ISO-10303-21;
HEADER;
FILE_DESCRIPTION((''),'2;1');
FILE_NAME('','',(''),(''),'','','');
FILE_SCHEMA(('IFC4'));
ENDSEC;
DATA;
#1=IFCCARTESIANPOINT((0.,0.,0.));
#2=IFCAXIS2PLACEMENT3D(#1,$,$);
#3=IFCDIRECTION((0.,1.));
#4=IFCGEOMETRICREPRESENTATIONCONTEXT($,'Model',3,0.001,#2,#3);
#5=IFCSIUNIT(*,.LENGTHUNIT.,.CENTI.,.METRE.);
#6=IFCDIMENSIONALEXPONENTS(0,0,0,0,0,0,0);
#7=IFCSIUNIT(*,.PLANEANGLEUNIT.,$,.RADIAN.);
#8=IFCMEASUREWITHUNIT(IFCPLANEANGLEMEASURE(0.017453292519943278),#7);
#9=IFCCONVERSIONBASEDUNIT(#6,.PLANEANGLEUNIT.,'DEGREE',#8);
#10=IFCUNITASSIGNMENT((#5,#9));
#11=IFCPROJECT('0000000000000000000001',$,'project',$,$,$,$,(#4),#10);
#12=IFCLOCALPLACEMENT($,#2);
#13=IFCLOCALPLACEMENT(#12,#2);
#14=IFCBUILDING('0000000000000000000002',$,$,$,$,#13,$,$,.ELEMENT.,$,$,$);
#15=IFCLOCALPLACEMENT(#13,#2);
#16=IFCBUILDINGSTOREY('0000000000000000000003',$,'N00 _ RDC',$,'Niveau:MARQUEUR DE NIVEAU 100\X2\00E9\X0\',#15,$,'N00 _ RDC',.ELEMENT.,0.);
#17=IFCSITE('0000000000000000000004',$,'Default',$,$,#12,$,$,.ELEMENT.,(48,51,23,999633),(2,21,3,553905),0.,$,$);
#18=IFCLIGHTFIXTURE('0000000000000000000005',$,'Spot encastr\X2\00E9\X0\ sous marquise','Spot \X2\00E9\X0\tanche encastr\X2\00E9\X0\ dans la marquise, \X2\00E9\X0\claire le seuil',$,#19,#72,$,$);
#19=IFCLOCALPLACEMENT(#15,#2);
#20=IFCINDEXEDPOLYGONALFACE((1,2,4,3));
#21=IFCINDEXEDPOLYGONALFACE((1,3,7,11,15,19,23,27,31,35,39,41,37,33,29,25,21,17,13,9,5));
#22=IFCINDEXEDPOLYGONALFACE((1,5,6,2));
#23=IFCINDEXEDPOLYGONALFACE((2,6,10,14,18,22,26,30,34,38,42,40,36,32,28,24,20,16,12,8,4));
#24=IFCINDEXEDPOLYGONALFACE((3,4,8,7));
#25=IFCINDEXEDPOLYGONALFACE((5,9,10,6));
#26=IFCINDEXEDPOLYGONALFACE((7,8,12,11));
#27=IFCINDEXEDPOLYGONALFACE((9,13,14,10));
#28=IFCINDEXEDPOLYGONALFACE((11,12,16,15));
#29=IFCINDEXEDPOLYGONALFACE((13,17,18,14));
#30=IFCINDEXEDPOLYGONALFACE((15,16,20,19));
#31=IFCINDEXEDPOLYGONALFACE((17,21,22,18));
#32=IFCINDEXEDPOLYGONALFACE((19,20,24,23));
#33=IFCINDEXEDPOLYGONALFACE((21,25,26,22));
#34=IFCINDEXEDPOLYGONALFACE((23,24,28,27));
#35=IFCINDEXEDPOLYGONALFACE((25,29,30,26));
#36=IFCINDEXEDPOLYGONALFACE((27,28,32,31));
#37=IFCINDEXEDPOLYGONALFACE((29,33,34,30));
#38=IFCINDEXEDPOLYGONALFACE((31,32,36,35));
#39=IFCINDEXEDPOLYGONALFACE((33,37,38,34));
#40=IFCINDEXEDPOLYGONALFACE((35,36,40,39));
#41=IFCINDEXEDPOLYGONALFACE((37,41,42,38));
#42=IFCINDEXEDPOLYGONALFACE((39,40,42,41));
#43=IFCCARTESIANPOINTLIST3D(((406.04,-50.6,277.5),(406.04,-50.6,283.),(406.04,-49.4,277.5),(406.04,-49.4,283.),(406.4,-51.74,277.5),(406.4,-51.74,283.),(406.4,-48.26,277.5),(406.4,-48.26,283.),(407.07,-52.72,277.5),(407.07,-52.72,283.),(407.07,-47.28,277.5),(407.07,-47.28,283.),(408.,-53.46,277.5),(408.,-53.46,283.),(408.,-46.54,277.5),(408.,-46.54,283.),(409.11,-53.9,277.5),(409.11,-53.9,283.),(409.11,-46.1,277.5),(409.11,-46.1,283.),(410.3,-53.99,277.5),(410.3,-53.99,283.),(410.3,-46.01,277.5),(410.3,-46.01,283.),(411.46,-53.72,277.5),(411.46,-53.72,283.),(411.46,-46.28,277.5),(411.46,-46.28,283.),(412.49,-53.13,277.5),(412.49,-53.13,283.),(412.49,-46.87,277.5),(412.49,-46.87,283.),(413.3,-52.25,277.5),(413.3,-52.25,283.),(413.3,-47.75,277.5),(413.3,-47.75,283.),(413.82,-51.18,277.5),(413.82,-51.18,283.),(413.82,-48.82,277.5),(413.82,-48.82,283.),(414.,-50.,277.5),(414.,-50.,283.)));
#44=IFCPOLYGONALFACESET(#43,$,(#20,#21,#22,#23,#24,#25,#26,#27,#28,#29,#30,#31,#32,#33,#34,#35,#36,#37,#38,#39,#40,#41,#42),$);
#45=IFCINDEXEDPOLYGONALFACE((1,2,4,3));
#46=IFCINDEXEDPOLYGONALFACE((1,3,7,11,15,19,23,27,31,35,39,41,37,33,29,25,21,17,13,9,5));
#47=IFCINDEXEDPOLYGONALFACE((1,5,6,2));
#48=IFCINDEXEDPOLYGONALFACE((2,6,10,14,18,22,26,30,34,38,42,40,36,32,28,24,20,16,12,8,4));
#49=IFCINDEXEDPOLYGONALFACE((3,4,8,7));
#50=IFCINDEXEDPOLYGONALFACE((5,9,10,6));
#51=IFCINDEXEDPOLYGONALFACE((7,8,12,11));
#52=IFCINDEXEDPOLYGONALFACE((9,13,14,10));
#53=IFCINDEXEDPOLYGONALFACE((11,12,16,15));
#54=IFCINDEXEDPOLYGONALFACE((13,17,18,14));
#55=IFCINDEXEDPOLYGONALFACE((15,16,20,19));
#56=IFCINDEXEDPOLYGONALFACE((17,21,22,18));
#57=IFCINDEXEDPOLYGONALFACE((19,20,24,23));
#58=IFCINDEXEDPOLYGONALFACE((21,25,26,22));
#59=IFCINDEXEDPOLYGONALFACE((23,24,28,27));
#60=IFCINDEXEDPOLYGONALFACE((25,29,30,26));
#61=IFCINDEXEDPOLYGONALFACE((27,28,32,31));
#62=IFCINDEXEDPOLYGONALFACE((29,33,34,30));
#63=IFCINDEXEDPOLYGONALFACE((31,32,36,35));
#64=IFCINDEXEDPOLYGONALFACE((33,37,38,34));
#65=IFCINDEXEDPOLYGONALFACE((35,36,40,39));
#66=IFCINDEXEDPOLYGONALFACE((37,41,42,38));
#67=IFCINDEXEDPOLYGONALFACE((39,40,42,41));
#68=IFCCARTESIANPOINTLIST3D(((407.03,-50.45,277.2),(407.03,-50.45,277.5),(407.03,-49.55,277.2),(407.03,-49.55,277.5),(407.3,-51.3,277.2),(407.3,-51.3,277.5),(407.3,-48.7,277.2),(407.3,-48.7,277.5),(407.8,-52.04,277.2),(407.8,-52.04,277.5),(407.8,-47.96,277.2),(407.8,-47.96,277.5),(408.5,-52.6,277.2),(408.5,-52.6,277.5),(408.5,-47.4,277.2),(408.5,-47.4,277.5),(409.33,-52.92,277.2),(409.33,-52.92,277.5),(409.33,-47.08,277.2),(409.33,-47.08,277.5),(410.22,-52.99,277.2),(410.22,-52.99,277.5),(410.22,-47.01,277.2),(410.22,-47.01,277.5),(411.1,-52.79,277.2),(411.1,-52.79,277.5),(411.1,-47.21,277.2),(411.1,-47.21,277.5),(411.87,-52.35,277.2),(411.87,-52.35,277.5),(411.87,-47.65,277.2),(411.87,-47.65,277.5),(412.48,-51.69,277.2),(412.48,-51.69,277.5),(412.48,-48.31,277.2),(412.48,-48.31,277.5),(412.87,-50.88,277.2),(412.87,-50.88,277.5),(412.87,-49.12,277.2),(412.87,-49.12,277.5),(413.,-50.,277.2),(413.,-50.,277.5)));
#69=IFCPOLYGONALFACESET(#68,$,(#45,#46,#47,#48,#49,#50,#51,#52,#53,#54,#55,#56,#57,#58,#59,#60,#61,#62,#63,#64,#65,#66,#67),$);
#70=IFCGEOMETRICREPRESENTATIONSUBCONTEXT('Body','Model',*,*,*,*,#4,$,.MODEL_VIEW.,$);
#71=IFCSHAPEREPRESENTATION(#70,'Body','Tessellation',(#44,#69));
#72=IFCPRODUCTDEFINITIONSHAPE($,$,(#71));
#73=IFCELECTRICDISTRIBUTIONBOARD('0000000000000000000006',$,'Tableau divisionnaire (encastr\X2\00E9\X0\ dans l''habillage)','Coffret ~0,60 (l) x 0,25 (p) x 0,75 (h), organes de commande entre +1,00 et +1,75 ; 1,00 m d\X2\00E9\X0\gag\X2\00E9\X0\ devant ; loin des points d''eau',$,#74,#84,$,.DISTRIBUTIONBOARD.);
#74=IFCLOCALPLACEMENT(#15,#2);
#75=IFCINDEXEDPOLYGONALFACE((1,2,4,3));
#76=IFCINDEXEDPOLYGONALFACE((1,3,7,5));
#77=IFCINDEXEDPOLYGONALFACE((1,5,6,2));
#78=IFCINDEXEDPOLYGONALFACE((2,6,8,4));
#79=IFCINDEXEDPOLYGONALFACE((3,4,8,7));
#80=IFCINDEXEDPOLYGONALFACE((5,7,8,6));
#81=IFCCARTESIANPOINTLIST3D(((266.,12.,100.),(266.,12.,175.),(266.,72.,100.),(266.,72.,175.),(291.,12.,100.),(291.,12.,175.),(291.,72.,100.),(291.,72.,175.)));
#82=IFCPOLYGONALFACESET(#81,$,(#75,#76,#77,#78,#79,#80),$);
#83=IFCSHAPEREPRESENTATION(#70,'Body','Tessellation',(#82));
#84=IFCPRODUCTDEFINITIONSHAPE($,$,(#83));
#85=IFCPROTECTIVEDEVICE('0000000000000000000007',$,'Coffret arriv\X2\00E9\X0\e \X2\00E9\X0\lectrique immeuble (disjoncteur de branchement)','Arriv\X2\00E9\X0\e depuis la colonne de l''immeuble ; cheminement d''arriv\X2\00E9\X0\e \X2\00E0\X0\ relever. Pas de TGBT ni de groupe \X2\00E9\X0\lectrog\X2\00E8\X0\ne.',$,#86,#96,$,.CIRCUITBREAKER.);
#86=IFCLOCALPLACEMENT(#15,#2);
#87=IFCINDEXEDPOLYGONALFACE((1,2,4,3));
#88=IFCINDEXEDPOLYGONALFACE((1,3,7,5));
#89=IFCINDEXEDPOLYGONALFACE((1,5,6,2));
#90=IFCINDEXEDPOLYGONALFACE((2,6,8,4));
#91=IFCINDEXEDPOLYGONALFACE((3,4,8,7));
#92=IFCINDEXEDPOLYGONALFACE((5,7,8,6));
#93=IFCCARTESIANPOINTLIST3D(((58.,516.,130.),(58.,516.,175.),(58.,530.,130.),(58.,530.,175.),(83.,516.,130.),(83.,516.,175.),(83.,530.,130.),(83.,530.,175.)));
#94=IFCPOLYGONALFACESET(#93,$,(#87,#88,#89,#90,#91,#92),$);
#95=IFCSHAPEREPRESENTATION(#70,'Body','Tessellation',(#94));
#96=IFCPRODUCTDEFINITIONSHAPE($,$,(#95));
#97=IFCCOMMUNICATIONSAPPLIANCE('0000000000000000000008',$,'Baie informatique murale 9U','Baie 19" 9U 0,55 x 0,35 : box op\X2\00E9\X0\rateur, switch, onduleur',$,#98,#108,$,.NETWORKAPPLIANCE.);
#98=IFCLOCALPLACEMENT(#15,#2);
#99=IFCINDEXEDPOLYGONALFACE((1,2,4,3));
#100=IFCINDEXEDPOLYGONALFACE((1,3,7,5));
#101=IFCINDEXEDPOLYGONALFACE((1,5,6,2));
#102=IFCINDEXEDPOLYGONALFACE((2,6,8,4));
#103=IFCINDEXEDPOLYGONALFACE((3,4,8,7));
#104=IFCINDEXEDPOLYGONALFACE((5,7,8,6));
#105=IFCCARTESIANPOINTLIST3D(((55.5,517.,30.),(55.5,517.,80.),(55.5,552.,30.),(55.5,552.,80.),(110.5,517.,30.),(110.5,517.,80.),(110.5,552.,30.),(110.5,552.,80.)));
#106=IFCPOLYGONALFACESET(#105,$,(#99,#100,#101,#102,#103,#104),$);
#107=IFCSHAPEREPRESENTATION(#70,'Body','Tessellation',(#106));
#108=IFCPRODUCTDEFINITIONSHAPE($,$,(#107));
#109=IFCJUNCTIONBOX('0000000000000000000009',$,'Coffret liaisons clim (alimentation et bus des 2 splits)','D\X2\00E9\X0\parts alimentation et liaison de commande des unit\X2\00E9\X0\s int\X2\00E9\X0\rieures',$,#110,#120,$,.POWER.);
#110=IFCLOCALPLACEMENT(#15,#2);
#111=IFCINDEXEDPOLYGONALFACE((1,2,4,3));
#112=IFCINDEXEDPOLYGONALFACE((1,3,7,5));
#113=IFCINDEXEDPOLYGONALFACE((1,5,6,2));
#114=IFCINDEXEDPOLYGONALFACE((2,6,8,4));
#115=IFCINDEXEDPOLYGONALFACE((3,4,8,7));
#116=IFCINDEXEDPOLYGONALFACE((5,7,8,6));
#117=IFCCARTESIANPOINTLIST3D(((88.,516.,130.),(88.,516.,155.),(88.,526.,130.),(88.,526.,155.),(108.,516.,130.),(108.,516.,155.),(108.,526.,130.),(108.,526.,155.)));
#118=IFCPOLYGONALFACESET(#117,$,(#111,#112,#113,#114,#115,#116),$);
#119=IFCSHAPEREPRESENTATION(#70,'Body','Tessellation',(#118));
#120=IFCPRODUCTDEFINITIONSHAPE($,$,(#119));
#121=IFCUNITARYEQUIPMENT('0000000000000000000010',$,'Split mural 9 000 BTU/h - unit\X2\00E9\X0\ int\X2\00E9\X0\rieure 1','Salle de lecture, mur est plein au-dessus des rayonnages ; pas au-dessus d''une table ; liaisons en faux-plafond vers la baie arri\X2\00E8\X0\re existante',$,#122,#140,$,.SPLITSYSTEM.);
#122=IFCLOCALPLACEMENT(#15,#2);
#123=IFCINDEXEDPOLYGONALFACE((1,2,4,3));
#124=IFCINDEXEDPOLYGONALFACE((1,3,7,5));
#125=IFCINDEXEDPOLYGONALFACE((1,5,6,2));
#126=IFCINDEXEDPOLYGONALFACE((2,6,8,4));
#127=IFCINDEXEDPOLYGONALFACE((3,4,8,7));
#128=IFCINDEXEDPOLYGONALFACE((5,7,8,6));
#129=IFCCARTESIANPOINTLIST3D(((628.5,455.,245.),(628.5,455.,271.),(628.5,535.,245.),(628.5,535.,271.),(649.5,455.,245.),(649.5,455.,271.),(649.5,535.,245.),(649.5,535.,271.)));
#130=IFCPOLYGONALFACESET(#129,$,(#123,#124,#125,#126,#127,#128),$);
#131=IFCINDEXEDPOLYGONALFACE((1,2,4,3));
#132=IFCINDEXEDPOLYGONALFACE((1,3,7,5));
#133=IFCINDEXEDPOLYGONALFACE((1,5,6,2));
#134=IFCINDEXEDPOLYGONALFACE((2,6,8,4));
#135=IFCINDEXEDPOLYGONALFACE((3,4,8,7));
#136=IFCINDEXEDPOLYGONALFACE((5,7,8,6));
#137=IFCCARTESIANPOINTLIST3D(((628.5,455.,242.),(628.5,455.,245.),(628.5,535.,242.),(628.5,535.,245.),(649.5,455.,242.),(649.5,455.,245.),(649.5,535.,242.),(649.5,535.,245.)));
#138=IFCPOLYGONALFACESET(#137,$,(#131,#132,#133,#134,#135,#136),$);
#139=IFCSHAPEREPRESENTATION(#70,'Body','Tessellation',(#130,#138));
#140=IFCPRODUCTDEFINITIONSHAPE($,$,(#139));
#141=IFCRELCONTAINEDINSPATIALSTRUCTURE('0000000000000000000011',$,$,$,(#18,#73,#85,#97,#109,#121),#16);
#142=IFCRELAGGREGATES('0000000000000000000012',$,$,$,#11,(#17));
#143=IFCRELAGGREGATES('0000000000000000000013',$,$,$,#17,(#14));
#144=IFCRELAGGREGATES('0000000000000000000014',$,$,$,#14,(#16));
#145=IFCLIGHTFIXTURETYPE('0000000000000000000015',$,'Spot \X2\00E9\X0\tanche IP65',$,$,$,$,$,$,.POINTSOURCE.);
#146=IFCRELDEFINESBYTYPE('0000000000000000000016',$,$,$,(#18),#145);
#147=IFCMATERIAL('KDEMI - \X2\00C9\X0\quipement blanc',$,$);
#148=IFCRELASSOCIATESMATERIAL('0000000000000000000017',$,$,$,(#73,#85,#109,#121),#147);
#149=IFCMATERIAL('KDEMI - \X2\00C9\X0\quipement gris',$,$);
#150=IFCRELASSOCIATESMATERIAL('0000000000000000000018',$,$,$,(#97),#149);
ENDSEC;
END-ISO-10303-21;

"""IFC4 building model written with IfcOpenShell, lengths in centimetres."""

from ifc_helpers import new_model, entity, si_unit, converted_unit, direction, frame, frame_2d, origin, origin_with_axes, place, context, subcontext, project, spatial, rectangle, circle, extrude, material, type_object, element, save


model = new_model("IFC4")

# Units and contexts
model_context = context("Model", 3, precision=0.001, world=origin(), true_north=direction((0.0, 1.0)))
body_context = subcontext(model_context, "Body", "Model", "MODEL_VIEW")
ifc_project = project(units=[si_unit("LENGTHUNIT", "METRE", prefix="CENTI"), converted_unit("PLANEANGLEUNIT", "DEGREE", entity("IfcPlaneAngleMeasure", 0.017453292519943278), si_unit("PLANEANGLEUNIT", "RADIAN"), dimensions=[0, 0, 0, 0, 0, 0, 0])], contexts=[model_context])

# Site, building, storey
site_placement = place(None, origin())
site = spatial("IfcSite", under=ifc_project, at=site_placement, Name="Default", CompositionType="ELEMENT", RefLatitude=(48, 51, 23, 999633), RefLongitude=(2, 21, 3, 553905), RefElevation=0.0)
building_placement = place(site_placement, origin())
building = spatial("IfcBuilding", under=site, at=building_placement, CompositionType="ELEMENT")
storey_placement = place(building_placement, origin())
storey = spatial("IfcBuildingStorey", under=building, at=storey_placement, Name="N00 _ RDC", ObjectType="Niveau:MARQUEUR DE NIVEAU 100é", LongName="N00 _ RDC", CompositionType="ELEMENT", Elevation=0.0)

# Light fixture
light_fixture_type_1 = type_object("IfcLightFixtureType", Name="Spot étanche IP65", PredefinedType="POINTSOURCE")
light_fixture_1_placement = place(storey_placement, origin_with_axes())
element("IfcLightFixture", 1, at=light_fixture_1_placement, inside=storey, type_object=light_fixture_type_1, Name="Spot encastré sous marquise", Description="Spot étanche encastré dans la marquise, éclaire le seuil", context=body_context, shape_type="SweptSolid", body=[
    extrude(circle(Radius=4.0, at=frame_2d((410.0, -50.0))), frame((0.0, 0.0, 277.5)), (0.0, 0.0, 1.0), 5.5),
    extrude(circle(Radius=3.0, at=frame_2d((410.0, -50.0))), frame((0.0, 0.0, 277.2)), (0.0, 0.0, 1.0), 0.3),
])

# Electric distribution board
ifc_material_1 = material(Name="KDEMI - Équipement blanc")
electric_distribution_board_placement = place(storey_placement, origin_with_axes())
element("IfcElectricDistributionBoard", 2, at=electric_distribution_board_placement, inside=storey, material=ifc_material_1, Name="Tableau divisionnaire (encastré dans l'habillage)", Description="Coffret ~0,60 (l) x 0,25 (p) x 0,75 (h), organes de commande entre +1,00 et +1,75 ; 1,00 m dégagé devant ; loin des points d'eau", PredefinedType="DISTRIBUTIONBOARD", context=body_context, shape_type="SweptSolid", body=[
    extrude(rectangle(XDim=25.0, YDim=60.0, at=frame_2d((278.5, 42.0))), frame((0.0, 0.0, 100.0)), (0.0, 0.0, 1.0), 75.0),
])

# Protective device
protective_device_placement = place(storey_placement, origin_with_axes())
element("IfcProtectiveDevice", 3, at=protective_device_placement, inside=storey, material=ifc_material_1, Name="Coffret arrivée électrique immeuble (disjoncteur de branchement)", Description="Arrivée depuis la colonne de l'immeuble ; cheminement d'arrivée à relever. Pas de TGBT ni de groupe électrogène.", PredefinedType="CIRCUITBREAKER", context=body_context, shape_type="SweptSolid", body=[
    extrude(rectangle(XDim=25.0, YDim=14.0, at=frame_2d((70.5, 523.0))), frame((0.0, 0.0, 130.0)), (0.0, 0.0, 1.0), 45.0),
])

# Communications appliance
ifc_material_2 = material(Name="KDEMI - Équipement gris")
communications_appliance_placement = place(storey_placement, origin_with_axes())
element("IfcCommunicationsAppliance", 4, at=communications_appliance_placement, inside=storey, material=ifc_material_2, Name="Baie informatique murale 9U", Description="Baie 19\" 9U 0,55 x 0,35 : box opérateur, switch, onduleur", PredefinedType="NETWORKAPPLIANCE", context=body_context, shape_type="SweptSolid", body=[
    extrude(rectangle(XDim=55.0, YDim=35.0, at=frame_2d((83.0, 534.5))), frame((0.0, 0.0, 30.0)), (0.0, 0.0, 1.0), 50.0),
])

# Junction box
junction_box_placement = place(storey_placement, origin_with_axes())
element("IfcJunctionBox", 5, at=junction_box_placement, inside=storey, material=ifc_material_1, Name="Coffret liaisons clim (alimentation et bus des 2 splits)", Description="Départs alimentation et liaison de commande des unités intérieures", PredefinedType="POWER", context=body_context, shape_type="SweptSolid", body=[
    extrude(rectangle(XDim=20.0, YDim=10.0, at=frame_2d((98.0, 521.0))), frame((0.0, 0.0, 130.0)), (0.0, 0.0, 1.0), 25.0),
])

# Unitary equipment
unitary_equipment_placement = place(storey_placement, origin_with_axes())
element("IfcUnitaryEquipment", 6, at=unitary_equipment_placement, inside=storey, material=ifc_material_1, Name="Split mural 9 000 BTU/h - unité intérieure 1", Description="Salle de lecture, mur est plein au-dessus des rayonnages ; pas au-dessus d'une table ; liaisons en faux-plafond vers la baie arrière existante", PredefinedType="SPLITSYSTEM", context=body_context, shape_type="SweptSolid", body=[
    extrude(rectangle(XDim=21.0, YDim=80.0, at=frame_2d((639.0, 495.0))), frame((0.0, 0.0, 245.0)), (0.0, 0.0, 1.0), 26.0),
    extrude(rectangle(XDim=21.0, YDim=80.0, at=frame_2d((639.0, 495.0))), frame((0.0, 0.0, 242.0)), (0.0, 0.0, 1.0), 3.0),
])

save(model, "model.ifc")
